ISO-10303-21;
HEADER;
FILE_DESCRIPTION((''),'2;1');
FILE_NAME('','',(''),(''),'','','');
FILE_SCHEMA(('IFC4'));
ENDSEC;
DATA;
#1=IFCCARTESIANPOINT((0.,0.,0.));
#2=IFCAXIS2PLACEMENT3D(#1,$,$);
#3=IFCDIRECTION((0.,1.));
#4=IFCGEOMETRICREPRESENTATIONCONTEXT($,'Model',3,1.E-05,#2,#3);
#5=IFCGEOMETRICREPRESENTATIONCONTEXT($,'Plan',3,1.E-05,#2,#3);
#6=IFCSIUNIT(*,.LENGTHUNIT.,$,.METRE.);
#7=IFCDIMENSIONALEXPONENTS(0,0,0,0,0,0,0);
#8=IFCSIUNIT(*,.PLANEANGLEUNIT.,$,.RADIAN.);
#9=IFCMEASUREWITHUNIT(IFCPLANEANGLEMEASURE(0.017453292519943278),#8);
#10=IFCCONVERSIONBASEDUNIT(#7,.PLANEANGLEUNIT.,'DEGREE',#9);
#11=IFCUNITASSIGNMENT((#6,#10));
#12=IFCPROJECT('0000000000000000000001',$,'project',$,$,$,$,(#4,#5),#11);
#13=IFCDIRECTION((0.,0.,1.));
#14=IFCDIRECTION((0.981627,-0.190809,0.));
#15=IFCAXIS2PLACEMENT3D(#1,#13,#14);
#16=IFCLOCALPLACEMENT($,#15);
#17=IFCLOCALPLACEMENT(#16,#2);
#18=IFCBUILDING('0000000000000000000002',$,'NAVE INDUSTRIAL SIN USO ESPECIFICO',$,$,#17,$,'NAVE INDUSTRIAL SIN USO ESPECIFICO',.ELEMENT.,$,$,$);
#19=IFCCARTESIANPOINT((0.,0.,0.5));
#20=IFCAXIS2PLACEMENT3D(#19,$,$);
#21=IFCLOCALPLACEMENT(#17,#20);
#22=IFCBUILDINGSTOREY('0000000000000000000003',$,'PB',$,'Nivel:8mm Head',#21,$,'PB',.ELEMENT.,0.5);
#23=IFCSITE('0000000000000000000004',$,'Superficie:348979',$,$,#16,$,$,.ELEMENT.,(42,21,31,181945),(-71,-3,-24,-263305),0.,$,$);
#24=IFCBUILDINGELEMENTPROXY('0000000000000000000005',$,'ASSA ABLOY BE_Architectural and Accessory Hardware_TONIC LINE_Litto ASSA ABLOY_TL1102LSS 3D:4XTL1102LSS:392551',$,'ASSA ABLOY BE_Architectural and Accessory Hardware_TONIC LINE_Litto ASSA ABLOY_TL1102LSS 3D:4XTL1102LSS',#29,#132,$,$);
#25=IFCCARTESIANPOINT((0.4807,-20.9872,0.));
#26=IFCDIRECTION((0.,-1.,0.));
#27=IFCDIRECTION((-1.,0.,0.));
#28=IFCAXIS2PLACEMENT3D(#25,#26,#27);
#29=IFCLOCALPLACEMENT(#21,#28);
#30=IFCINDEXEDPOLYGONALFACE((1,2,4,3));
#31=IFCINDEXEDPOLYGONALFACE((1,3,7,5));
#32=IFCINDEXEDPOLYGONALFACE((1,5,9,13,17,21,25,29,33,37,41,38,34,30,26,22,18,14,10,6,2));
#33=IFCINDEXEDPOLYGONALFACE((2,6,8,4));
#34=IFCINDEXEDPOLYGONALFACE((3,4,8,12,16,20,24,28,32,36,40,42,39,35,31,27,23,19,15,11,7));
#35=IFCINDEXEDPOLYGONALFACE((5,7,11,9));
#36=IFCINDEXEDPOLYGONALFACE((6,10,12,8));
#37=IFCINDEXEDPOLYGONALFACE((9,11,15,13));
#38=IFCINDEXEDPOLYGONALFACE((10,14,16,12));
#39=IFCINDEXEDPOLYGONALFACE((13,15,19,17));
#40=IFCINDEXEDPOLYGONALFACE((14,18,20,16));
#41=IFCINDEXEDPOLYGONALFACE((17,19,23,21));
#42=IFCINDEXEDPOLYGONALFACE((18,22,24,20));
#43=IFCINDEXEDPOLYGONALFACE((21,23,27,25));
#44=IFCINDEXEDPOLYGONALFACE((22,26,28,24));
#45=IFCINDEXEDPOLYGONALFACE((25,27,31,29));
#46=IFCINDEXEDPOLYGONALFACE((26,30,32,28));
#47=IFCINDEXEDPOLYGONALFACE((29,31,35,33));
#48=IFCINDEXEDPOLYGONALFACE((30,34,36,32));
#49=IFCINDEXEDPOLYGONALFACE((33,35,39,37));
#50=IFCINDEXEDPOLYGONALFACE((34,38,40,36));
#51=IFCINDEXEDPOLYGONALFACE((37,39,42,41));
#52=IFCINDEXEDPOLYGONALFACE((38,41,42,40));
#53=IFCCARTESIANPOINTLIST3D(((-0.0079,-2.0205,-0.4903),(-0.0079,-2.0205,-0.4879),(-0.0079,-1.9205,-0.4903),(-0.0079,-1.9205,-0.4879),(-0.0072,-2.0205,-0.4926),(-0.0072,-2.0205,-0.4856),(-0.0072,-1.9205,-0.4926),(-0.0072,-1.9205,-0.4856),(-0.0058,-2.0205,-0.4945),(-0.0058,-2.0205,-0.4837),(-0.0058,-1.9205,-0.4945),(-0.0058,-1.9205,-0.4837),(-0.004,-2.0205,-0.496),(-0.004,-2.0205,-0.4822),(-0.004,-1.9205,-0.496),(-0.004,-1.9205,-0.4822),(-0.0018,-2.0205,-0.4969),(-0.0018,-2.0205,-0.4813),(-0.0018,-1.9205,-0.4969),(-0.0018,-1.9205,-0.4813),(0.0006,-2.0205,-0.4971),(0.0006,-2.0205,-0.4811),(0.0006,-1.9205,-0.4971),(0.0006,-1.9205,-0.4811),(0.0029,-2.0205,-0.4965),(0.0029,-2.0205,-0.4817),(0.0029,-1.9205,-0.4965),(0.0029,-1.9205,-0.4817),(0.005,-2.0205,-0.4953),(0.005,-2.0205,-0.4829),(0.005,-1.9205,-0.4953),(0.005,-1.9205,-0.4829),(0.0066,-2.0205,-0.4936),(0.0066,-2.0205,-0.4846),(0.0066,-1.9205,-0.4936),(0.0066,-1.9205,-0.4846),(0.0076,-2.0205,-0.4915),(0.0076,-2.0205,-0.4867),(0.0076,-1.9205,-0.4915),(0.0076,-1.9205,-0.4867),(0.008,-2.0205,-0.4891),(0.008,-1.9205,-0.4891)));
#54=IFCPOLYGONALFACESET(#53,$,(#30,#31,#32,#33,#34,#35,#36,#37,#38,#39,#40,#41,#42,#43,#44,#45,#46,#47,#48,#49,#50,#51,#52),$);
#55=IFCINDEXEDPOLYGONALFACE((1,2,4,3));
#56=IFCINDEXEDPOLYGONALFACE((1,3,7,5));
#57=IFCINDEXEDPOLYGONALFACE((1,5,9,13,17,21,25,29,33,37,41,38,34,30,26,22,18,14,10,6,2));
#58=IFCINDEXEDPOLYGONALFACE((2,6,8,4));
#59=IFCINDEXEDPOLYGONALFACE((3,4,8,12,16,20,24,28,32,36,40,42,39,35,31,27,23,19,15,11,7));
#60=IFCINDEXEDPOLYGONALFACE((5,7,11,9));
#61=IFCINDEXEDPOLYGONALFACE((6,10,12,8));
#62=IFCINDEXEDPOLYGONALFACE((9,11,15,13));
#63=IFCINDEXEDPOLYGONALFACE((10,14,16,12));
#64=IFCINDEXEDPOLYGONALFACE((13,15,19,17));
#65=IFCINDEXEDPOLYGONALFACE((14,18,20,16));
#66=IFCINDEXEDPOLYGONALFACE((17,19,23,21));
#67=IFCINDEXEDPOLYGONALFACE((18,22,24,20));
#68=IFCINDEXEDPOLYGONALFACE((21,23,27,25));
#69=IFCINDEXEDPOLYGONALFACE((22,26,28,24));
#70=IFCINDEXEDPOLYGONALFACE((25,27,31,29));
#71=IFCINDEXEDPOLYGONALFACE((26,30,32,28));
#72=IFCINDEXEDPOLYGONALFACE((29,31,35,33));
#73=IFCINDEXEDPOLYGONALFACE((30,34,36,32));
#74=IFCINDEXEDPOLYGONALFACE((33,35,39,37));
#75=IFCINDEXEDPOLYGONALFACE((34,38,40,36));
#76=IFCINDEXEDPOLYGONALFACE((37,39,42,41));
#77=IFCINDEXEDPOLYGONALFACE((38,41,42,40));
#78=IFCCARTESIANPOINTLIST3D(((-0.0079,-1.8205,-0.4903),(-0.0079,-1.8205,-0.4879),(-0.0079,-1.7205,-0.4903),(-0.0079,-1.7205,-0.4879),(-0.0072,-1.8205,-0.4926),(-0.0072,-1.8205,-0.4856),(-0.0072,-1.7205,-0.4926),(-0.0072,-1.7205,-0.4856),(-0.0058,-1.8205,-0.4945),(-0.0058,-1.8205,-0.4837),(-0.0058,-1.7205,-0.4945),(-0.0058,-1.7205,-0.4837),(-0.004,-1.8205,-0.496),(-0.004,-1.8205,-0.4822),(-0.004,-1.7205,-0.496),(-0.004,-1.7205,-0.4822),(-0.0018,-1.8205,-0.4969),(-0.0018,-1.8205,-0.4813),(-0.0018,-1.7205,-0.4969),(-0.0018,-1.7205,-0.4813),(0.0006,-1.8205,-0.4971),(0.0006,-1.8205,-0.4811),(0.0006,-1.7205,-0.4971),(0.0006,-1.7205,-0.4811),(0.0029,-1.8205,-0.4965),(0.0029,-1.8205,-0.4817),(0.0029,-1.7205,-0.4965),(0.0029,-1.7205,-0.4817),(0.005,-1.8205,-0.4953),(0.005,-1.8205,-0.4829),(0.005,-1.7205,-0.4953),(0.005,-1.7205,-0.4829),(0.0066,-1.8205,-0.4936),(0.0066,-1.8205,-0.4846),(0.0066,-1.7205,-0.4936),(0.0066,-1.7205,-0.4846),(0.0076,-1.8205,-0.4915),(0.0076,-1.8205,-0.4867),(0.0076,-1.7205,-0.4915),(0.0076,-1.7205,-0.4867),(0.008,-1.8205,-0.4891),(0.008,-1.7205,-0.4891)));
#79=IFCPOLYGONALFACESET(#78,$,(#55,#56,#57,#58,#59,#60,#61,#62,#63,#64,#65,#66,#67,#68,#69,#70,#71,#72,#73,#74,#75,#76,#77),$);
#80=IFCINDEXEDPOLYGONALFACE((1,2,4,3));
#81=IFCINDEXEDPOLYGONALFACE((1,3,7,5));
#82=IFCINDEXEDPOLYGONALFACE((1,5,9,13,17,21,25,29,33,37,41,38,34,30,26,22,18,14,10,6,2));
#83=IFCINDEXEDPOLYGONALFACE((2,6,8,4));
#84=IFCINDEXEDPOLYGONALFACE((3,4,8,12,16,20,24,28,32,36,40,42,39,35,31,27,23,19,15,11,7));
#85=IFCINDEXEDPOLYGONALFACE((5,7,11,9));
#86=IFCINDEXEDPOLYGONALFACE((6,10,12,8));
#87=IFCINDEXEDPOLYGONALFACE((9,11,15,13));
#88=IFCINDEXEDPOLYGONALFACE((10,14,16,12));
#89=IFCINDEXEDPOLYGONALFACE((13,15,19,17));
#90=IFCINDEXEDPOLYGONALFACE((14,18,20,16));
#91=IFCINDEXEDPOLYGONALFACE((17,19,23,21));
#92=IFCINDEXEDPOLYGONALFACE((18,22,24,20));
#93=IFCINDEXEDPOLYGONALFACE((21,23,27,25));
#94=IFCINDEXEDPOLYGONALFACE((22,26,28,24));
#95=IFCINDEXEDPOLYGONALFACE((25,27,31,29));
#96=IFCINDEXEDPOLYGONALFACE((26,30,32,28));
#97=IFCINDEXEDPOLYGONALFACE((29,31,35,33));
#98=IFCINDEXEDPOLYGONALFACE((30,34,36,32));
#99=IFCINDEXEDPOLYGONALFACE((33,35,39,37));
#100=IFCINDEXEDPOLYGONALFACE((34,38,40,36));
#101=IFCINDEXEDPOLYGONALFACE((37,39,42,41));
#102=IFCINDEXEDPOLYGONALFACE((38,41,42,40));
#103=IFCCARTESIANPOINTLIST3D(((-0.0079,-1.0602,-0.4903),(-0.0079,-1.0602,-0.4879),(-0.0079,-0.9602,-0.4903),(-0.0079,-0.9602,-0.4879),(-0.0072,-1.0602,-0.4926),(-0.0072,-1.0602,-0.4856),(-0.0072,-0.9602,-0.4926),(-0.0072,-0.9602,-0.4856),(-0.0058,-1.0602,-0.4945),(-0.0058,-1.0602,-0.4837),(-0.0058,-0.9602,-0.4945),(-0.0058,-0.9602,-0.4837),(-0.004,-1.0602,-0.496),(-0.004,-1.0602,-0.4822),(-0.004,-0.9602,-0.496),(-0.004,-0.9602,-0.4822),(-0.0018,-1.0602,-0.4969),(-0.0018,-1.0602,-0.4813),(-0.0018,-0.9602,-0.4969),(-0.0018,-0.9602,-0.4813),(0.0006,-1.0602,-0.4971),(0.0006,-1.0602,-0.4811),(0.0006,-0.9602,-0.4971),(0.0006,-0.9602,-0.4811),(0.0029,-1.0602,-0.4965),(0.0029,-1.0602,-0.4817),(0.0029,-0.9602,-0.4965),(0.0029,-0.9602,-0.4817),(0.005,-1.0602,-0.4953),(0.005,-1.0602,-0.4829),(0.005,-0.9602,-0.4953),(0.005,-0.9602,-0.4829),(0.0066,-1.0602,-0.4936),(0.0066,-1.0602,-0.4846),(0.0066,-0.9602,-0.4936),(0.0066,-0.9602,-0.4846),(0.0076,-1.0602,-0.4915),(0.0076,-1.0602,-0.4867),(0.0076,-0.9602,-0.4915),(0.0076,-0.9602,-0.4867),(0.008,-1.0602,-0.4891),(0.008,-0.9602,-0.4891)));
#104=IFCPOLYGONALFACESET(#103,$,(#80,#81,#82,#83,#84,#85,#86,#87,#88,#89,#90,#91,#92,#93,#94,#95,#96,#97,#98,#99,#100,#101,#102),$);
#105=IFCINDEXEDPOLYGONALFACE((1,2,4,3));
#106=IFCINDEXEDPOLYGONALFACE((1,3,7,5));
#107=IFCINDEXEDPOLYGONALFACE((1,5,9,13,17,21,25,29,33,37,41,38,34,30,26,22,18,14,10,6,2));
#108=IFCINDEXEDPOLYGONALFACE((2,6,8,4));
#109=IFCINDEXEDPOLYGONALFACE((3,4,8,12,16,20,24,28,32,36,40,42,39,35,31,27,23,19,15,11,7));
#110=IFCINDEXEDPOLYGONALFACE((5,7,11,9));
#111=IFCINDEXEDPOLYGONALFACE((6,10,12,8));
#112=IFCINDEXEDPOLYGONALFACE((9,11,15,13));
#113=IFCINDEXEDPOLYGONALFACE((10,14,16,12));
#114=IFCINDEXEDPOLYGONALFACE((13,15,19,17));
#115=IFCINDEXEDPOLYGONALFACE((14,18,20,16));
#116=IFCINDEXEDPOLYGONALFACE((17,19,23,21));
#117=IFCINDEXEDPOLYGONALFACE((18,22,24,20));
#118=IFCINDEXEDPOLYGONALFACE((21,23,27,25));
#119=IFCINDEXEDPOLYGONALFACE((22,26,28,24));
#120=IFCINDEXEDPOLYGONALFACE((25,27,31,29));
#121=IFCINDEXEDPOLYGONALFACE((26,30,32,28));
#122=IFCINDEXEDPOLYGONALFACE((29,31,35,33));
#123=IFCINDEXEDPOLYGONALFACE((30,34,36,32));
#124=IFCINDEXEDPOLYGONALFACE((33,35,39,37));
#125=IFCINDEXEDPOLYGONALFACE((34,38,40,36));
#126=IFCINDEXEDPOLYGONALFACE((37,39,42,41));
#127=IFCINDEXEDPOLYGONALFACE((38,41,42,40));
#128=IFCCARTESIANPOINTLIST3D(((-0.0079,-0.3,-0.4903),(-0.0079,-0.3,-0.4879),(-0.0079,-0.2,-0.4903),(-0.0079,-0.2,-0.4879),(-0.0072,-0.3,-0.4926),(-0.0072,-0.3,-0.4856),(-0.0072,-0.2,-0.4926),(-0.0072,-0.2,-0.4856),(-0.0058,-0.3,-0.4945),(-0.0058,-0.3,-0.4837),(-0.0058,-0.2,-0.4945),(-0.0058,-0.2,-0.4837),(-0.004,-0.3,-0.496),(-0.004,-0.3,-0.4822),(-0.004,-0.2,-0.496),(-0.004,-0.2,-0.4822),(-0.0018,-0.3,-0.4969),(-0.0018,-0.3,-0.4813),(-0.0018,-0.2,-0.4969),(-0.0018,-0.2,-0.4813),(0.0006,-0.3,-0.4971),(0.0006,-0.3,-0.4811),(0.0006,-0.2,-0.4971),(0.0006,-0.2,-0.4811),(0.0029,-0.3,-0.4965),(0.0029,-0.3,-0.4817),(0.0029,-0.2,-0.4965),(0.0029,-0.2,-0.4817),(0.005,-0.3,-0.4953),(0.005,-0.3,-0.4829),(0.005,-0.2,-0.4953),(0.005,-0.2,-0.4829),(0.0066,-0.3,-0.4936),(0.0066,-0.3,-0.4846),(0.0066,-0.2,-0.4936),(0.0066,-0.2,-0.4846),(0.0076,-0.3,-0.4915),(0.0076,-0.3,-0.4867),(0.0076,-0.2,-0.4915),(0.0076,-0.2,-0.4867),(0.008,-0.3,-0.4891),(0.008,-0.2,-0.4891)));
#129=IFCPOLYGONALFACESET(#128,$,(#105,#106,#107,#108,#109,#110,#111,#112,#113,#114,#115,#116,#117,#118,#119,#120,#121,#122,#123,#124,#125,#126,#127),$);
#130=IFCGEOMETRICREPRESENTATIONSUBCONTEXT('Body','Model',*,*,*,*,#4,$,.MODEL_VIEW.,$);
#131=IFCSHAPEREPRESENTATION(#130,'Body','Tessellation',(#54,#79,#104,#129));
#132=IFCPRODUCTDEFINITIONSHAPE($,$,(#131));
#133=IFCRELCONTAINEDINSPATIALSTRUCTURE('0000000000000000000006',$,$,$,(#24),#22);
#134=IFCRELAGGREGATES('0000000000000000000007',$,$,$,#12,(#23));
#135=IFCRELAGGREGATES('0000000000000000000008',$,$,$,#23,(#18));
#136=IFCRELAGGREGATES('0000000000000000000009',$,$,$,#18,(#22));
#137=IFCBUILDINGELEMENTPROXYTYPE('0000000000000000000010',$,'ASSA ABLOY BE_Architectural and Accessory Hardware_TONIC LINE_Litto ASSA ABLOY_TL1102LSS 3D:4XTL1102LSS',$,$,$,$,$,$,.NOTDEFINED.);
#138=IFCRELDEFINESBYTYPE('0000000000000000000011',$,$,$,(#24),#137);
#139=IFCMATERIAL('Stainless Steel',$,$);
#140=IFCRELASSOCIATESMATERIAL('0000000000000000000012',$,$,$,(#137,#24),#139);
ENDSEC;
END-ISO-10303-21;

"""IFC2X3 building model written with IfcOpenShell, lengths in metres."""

from ifc_helpers import new_model, entity, si_unit, converted_unit, direction, frame, frame_2d, origin, place, context, subcontext, project, spatial, circle, extrude, source, transform, mapped, material, type_object, type_shapes, element, save


model = new_model("IFC2X3")

# Units and contexts
model_context = context("Model", 3, precision=1e-05, world=origin(), true_north=direction((0.0, 1.0)))
plan_context = context("Plan", 3, precision=1e-05, world=origin(), true_north=direction((0.0, 1.0)))
body_context = subcontext(model_context, "Body", "Model", "MODEL_VIEW")
ifc_project = project(units=[si_unit("LENGTHUNIT", "METRE"), converted_unit("PLANEANGLEUNIT", "DEGREE", entity("IfcPlaneAngleMeasure", 0.017453292519943278), si_unit("PLANEANGLEUNIT", "RADIAN"), dimensions=[0, 0, 0, 0, 0, 0, 0])], contexts=[model_context, plan_context])

# Site, building, storey
site_placement = place(None, frame((0.0, 0.0, 0.0), z_axis=(0.0, 0.0, 1.0), x_axis=(0.981627, -0.190809, 0.0)))
site = spatial("IfcSite", under=ifc_project, at=site_placement, Name="Superficie:348979", CompositionType="ELEMENT", RefLatitude=(42, 21, 31, 181945), RefLongitude=(-71, -3, -24, -263305), RefElevation=0.0)
building_placement = place(site_placement, origin())
building = spatial("IfcBuilding", under=site, at=building_placement, Name="NAVE INDUSTRIAL SIN USO ESPECIFICO", LongName="NAVE INDUSTRIAL SIN USO ESPECIFICO", CompositionType="ELEMENT")
storey_placement = place(building_placement, frame((0.0, 0.0, 0.5)))
storey = spatial("IfcBuildingStorey", under=building, at=storey_placement, Name="PB", ObjectType="Nivel:8mm Head", LongName="PB", CompositionType="ELEMENT", Elevation=0.5)

# Building element proxy
ifc_material_1 = material(Name="Stainless Steel")
building_element_proxy_type_1 = type_object("IfcBuildingElementProxyType", Name="ASSA ABLOY BE_Architectural and Accessory Hardware_TONIC LINE_Litto ASSA ABLOY_TL1102LSS 3D:4XTL1102LSS", PredefinedType="NOTDEFINED", material=ifc_material_1)
shared_shape_1 = source(origin(), body_context, "Body", "SweptSolid", [
    extrude(circle(Radius=0.008, at=frame_2d((0.0, 0.0), x_axis=(1.0, 0.0))), frame((0.0, -2.0205, -0.4891), z_axis=(0.0, 1.0, 0.0), x_axis=(1.0, 0.0, 0.0)), (0.0, 0.0, 1.0), 0.1),
    extrude(circle(Radius=0.008, at=frame_2d((0.0, 0.0), x_axis=(1.0, 0.0))), frame((0.0, -1.8205, -0.4891), z_axis=(0.0, 1.0, 0.0), x_axis=(1.0, 0.0, 0.0)), (0.0, 0.0, 1.0), 0.1),
    extrude(circle(Radius=0.008, at=frame_2d((0.0, 0.0), x_axis=(1.0, 0.0))), frame((0.0, -1.0602, -0.4891), z_axis=(0.0, 1.0, 0.0), x_axis=(1.0, 0.0, 0.0)), (0.0, 0.0, 1.0), 0.1),
    extrude(circle(Radius=0.008, at=frame_2d((0.0, 0.0), x_axis=(1.0, 0.0))), frame((0.0, -0.3, -0.4891), z_axis=(0.0, 1.0, 0.0), x_axis=(1.0, 0.0, 0.0)), (0.0, 0.0, 1.0), 0.1),
])
type_shapes(building_element_proxy_type_1, [shared_shape_1])
for number, where, z_axis, x_axis, name in (
    (1, (0.4807, -20.9872, 0.0), (0.0, -1.0, 0.0), (-1.0, 0.0, 0.0), "ASSA ABLOY BE_Architectural and Accessory Hardware_TONIC LINE_Litto ASSA ABLOY_TL1102LSS 3D:4XTL1102LSS:392551"),
):
    element("IfcBuildingElementProxy", number, at=place(storey_placement, frame(where, z_axis=z_axis, x_axis=x_axis)), inside=storey, type_object=building_element_proxy_type_1, material=ifc_material_1, Name=name, ObjectType="ASSA ABLOY BE_Architectural and Accessory Hardware_TONIC LINE_Litto ASSA ABLOY_TL1102LSS 3D:4XTL1102LSS", context=body_context, shape_type="MappedRepresentation", body=[
        mapped(shared_shape_1, transform((0.0, 0.0, 0.0), scale=1.0)),
    ])

save(model, "model.ifc")
